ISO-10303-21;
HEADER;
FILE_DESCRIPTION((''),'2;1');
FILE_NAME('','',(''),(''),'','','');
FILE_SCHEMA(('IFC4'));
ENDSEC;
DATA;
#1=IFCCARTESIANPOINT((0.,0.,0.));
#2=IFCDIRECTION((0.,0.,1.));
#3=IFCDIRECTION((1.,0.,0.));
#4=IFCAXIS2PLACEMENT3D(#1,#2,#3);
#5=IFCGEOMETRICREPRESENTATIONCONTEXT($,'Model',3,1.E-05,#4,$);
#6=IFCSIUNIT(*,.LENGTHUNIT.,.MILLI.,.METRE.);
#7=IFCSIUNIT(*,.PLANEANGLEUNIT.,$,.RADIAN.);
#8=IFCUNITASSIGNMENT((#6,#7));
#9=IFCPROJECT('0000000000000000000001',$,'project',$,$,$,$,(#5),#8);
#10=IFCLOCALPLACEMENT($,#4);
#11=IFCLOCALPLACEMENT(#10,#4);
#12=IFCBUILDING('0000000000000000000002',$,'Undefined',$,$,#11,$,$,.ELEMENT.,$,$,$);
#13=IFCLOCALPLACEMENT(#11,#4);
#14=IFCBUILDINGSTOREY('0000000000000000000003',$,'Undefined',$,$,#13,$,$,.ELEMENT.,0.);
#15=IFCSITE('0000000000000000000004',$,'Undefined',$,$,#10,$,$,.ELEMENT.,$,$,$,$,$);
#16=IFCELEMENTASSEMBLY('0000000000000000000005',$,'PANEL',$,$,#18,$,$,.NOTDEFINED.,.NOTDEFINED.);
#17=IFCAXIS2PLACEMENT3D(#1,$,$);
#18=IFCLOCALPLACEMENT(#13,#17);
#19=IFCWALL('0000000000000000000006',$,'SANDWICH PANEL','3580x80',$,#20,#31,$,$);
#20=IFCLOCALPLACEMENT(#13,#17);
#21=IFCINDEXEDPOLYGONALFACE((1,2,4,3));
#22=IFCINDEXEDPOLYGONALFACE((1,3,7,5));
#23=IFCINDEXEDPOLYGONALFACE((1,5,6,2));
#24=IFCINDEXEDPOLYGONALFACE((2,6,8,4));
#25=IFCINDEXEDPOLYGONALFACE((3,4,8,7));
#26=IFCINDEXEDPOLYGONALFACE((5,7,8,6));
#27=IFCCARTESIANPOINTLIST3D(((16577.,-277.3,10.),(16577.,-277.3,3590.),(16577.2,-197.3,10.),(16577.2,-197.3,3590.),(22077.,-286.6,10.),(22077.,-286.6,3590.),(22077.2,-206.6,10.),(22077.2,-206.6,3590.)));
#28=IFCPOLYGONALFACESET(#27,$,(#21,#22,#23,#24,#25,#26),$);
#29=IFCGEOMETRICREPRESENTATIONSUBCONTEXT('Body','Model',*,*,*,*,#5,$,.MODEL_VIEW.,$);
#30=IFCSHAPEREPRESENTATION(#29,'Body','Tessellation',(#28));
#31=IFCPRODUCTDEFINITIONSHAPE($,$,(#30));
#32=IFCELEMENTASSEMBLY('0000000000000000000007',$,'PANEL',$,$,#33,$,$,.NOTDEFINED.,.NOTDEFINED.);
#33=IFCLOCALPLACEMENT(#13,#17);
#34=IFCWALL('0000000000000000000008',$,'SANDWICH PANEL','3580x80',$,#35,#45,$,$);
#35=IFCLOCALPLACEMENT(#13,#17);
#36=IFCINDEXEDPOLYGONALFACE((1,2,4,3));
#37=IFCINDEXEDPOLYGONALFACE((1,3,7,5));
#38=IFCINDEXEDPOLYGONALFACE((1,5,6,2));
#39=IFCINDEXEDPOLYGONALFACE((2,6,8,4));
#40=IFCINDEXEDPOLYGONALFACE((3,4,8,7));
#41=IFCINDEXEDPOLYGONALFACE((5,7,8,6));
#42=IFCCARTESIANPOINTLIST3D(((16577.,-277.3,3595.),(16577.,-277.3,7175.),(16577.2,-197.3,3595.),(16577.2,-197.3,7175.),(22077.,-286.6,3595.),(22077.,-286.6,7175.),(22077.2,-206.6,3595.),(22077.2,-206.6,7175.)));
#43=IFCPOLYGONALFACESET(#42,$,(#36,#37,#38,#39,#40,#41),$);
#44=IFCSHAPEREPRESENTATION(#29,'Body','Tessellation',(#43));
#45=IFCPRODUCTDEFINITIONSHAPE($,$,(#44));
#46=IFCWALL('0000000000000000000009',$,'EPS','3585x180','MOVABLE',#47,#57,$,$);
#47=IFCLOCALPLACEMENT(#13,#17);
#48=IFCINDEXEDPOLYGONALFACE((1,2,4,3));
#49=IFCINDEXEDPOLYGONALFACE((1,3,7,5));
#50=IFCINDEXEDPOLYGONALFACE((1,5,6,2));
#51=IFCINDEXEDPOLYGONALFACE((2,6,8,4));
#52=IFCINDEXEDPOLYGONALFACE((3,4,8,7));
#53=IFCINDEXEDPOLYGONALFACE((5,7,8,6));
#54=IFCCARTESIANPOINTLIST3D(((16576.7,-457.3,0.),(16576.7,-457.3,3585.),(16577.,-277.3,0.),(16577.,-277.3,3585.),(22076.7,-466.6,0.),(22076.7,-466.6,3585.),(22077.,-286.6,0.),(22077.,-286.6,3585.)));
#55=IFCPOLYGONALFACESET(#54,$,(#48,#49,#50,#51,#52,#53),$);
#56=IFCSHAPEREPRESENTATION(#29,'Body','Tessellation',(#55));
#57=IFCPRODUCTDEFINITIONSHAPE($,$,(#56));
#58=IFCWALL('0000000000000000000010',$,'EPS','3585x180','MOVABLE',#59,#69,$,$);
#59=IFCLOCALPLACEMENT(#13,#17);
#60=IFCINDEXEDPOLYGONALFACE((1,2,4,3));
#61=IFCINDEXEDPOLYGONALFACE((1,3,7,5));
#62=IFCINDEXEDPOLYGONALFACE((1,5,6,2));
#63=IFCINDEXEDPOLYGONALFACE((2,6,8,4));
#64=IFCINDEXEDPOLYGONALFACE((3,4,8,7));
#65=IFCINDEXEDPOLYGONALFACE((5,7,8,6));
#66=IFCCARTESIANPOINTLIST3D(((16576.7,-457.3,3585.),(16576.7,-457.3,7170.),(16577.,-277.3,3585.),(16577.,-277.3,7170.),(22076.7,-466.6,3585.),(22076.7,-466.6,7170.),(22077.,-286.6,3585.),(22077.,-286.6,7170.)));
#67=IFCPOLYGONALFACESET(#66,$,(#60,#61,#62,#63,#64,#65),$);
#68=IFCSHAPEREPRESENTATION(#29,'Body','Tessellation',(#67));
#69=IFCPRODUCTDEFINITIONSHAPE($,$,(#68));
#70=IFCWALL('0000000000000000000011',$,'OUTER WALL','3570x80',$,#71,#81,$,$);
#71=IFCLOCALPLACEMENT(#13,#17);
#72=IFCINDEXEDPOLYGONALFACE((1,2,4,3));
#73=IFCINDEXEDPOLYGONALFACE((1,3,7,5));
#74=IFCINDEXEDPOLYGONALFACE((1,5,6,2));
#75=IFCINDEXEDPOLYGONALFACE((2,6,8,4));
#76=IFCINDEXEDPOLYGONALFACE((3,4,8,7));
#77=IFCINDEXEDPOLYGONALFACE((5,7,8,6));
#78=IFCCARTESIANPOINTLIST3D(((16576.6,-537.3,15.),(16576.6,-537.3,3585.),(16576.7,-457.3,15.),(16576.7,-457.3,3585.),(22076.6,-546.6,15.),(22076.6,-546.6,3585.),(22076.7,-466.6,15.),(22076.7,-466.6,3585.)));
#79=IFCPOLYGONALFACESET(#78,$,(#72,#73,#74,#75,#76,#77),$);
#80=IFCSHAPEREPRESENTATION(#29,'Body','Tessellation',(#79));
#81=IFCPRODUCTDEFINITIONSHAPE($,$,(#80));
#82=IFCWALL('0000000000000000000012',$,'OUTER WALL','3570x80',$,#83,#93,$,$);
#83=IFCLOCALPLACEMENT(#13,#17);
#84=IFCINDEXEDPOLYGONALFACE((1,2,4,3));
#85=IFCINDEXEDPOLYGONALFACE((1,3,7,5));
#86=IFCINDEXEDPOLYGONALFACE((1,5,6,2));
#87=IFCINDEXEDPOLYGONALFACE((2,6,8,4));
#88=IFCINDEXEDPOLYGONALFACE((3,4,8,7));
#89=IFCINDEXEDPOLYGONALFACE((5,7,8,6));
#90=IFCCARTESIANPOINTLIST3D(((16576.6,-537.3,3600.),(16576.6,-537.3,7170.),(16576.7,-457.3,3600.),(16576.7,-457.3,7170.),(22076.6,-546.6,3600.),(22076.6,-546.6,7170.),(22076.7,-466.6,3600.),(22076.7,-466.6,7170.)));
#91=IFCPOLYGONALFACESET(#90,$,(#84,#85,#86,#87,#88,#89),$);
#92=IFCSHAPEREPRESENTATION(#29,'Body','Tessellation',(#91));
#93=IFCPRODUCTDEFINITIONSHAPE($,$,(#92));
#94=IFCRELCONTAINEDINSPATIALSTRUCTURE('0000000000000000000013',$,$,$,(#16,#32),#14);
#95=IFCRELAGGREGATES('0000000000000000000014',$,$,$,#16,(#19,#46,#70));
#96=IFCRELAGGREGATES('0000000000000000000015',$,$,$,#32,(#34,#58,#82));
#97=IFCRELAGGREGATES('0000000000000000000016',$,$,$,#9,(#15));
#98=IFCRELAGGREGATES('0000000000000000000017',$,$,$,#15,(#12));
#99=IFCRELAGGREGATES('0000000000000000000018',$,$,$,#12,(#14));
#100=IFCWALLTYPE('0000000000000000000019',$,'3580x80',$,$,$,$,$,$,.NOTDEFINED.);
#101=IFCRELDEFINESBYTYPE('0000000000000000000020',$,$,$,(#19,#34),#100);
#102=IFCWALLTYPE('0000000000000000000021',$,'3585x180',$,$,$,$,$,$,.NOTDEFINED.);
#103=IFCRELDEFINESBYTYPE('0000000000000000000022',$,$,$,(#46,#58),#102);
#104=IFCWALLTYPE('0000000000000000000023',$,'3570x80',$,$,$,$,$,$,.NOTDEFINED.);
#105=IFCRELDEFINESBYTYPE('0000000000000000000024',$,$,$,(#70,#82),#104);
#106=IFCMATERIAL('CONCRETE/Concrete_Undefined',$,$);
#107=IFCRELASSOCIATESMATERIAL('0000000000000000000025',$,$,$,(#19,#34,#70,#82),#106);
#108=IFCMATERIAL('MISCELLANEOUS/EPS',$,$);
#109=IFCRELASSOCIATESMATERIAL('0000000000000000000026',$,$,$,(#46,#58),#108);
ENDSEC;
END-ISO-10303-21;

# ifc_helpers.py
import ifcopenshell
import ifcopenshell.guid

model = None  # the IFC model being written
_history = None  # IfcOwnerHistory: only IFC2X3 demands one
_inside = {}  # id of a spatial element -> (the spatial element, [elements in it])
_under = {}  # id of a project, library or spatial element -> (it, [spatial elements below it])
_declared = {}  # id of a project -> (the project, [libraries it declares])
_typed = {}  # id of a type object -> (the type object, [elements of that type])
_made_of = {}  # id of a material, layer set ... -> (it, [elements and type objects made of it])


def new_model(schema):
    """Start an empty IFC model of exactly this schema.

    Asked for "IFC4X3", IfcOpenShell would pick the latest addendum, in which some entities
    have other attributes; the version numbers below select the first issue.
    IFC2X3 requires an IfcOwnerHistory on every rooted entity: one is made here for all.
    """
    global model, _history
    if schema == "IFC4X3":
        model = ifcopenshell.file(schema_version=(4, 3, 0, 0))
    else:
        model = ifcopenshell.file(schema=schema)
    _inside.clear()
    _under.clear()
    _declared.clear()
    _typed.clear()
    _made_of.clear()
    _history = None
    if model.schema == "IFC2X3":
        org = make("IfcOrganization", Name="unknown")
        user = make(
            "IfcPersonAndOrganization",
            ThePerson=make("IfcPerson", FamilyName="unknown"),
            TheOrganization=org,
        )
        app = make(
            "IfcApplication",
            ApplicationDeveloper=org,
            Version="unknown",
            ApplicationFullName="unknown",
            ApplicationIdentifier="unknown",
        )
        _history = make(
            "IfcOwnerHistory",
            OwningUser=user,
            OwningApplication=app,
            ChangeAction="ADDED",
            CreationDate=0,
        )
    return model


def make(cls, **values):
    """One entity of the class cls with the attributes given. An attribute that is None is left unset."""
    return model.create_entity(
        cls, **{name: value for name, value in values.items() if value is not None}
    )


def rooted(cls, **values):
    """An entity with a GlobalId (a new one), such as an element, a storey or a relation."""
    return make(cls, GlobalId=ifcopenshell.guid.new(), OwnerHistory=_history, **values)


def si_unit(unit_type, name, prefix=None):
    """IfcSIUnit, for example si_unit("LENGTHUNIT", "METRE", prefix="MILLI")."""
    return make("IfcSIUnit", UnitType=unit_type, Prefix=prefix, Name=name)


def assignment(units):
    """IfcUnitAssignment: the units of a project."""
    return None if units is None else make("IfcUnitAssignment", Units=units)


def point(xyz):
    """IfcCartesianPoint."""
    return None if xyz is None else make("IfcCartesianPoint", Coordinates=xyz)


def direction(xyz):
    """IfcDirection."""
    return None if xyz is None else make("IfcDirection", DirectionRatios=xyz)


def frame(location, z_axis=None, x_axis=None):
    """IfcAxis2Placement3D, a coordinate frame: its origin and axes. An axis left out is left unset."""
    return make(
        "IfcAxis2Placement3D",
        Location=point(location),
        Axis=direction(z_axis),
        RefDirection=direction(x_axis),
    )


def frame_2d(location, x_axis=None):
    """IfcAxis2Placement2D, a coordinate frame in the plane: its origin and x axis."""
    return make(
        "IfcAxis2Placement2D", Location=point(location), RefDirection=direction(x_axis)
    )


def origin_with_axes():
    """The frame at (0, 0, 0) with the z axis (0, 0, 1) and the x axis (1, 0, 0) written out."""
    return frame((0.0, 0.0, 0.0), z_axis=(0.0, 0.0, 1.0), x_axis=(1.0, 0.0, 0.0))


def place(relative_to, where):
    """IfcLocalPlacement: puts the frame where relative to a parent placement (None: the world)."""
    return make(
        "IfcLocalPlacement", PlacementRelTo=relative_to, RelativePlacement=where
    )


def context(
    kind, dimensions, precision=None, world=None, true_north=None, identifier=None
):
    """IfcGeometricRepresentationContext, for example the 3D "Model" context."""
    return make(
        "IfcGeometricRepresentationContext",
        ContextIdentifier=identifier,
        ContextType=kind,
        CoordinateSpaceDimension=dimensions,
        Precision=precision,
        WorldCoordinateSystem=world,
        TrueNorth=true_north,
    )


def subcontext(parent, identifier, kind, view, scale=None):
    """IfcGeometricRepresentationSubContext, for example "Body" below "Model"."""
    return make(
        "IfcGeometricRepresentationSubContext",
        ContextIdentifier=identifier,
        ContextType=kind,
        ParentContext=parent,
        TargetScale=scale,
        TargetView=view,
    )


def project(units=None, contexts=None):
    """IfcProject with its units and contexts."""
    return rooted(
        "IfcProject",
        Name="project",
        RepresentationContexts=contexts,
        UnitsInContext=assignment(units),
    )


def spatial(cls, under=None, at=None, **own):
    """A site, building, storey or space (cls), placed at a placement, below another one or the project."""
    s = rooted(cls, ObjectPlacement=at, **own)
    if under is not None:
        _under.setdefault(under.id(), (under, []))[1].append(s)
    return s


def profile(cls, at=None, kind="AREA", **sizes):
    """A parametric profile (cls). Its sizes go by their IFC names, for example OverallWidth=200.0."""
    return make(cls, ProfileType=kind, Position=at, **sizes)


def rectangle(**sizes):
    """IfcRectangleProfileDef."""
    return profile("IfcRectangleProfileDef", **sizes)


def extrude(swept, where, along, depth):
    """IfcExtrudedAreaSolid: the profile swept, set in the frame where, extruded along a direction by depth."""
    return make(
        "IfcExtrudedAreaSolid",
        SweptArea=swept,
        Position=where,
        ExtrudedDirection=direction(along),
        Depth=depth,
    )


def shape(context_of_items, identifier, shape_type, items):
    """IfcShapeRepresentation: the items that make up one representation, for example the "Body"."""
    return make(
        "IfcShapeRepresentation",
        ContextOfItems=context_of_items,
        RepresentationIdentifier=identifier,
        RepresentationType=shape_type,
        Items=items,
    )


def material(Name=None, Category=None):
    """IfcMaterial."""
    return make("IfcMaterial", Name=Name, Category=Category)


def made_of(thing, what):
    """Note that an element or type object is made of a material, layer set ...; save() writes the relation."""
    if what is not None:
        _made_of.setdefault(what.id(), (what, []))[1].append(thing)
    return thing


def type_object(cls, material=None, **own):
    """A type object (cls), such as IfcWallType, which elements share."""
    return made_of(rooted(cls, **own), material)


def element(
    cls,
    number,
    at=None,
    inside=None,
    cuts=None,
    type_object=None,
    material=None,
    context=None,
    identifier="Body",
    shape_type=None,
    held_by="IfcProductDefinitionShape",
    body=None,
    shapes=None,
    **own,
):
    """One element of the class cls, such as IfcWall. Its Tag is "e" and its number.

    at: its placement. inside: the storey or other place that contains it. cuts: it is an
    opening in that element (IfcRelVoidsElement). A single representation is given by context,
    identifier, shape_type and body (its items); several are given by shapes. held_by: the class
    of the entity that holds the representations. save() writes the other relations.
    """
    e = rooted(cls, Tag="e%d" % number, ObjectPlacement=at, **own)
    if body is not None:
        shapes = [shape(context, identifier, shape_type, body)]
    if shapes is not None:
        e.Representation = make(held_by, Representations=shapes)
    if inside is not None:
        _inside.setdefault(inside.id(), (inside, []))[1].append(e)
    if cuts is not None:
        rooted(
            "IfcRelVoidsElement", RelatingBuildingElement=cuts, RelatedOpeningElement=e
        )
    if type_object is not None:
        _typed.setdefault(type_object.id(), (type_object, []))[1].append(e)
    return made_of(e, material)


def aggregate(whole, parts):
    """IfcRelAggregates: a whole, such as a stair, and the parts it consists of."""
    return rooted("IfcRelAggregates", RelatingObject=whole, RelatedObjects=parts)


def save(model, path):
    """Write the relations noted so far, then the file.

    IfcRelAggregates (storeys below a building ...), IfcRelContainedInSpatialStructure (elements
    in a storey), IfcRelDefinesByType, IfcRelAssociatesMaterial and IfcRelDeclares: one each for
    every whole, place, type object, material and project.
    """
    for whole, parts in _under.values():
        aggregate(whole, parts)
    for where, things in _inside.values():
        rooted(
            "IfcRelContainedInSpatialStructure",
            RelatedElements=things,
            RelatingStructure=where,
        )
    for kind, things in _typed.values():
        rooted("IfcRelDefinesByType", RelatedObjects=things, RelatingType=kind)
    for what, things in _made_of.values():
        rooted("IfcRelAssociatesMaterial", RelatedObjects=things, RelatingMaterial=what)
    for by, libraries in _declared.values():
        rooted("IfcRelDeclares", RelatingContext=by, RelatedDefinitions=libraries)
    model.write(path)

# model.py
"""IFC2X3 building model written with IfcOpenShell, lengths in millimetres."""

from ifc_helpers import new_model, si_unit, frame, frame_2d, origin_with_axes, place, context, subcontext, project, spatial, rectangle, extrude, material, type_object, element, aggregate, save


model = new_model("IFC2X3")

# Units and contexts
model_context = context("Model", 3, precision=1e-05, world=origin_with_axes())
body_context = subcontext(model_context, "Body", "Model", "MODEL_VIEW")
ifc_project = project(units=[si_unit("LENGTHUNIT", "METRE", prefix="MILLI"), si_unit("PLANEANGLEUNIT", "RADIAN")], contexts=[model_context])

# Site, building, storey
site_placement = place(None, origin_with_axes())
site = spatial("IfcSite", under=ifc_project, at=site_placement, Name="Undefined", CompositionType="ELEMENT")
building_placement = place(site_placement, origin_with_axes())
building = spatial("IfcBuilding", under=site, at=building_placement, Name="Undefined", CompositionType="ELEMENT")
storey_placement = place(building_placement, origin_with_axes())
storey = spatial("IfcBuildingStorey", under=building, at=storey_placement, Name="Undefined", CompositionType="ELEMENT", Elevation=0.0)

# Shared definitions
ifc_material_1 = material(Name="CONCRETE/Concrete_Undefined")

# Element assemblies, walls
assembly_1_placement = place(storey_placement, origin_with_axes())
assembly_1 = element("IfcElementAssembly", 1, at=assembly_1_placement, inside=storey, Name="PANEL", AssemblyPlace="NOTDEFINED", PredefinedType="NOTDEFINED")
wall_type_1 = type_object("IfcWallType", Name="3580x80", PredefinedType="NOTDEFINED")
wall_1_placement = place(assembly_1_placement, frame((16577.1, -237.3, 10.0), z_axis=(0.0, 0.0, 1.0), x_axis=(0.999999, -0.001684, 0.0)))
wall_1 = element("IfcWall", 2, at=wall_1_placement, type_object=wall_type_1, material=ifc_material_1, Name="SANDWICH PANEL", Description="3580x80", context=body_context, shape_type="SweptSolid", body=[
    extrude(rectangle(XDim=5500.0, YDim=80.0, at=frame_2d((0.0, 2750.0), x_axis=(0.0, -1.0))), frame((0.0, 0.0, 0.0), z_axis=(0.0, 0.0, 1.0), x_axis=(0.0, -1.0, 0.0)), (0.0, 0.0, 1.0), 3580.0),
])
assembly_2_placement = place(storey_placement, origin_with_axes())
assembly_2 = element("IfcElementAssembly", 3, at=assembly_2_placement, inside=storey, Name="PANEL", AssemblyPlace="NOTDEFINED", PredefinedType="NOTDEFINED")
wall_2_placement = place(assembly_2_placement, frame((16577.1, -237.3, 3595.0), z_axis=(0.0, 0.0, 1.0), x_axis=(0.999999, -0.001684, 0.0)))
wall_2 = element("IfcWall", 4, at=wall_2_placement, type_object=wall_type_1, material=ifc_material_1, Name="SANDWICH PANEL", Description="3580x80", context=body_context, shape_type="SweptSolid", body=[
    extrude(rectangle(XDim=5500.0, YDim=80.0, at=frame_2d((0.0, 2750.0), x_axis=(0.0, -1.0))), frame((0.0, 0.0, 0.0), z_axis=(0.0, 0.0, 1.0), x_axis=(0.0, -1.0, 0.0)), (0.0, 0.0, 1.0), 3580.0),
])

# Walls
ifc_material_2 = material(Name="MISCELLANEOUS/EPS")
wall_type_2 = type_object("IfcWallType", Name="3585x180", PredefinedType="NOTDEFINED")
wall_3_placement = place(assembly_1_placement, frame((16576.9, -367.3, 0.0), z_axis=(0.0, 0.0, 1.0), x_axis=(0.999999, -0.001684, 0.0)))
wall_3 = element("IfcWall", 5, at=wall_3_placement, type_object=wall_type_2, material=ifc_material_2, Name="EPS", Description="3585x180", ObjectType="MOVABLE", context=body_context, shape_type="SweptSolid", body=[
    extrude(rectangle(XDim=5500.0, YDim=180.0, at=frame_2d((0.0, 2750.0), x_axis=(0.0, -1.0))), frame((0.0, 0.0, 0.0), z_axis=(0.0, 0.0, 1.0), x_axis=(0.0, -1.0, 0.0)), (0.0, 0.0, 1.0), 3585.0),
])
wall_4_placement = place(assembly_2_placement, frame((16576.9, -367.3, 3585.0), z_axis=(0.0, 0.0, 1.0), x_axis=(0.999999, -0.001684, 0.0)))
wall_4 = element("IfcWall", 6, at=wall_4_placement, type_object=wall_type_2, material=ifc_material_2, Name="EPS", Description="3585x180", ObjectType="MOVABLE", context=body_context, shape_type="SweptSolid", body=[
    extrude(rectangle(XDim=5500.0, YDim=180.0, at=frame_2d((0.0, 2750.0), x_axis=(0.0, -1.0))), frame((0.0, 0.0, 0.0), z_axis=(0.0, 0.0, 1.0), x_axis=(0.0, -1.0, 0.0)), (0.0, 0.0, 1.0), 3585.0),
])
wall_type_3 = type_object("IfcWallType", Name="3570x80", PredefinedType="NOTDEFINED")
wall_5_placement = place(assembly_1_placement, frame((16576.7, -497.3, 15.0), z_axis=(0.0, 0.0, 1.0), x_axis=(0.999999, -0.001684, 0.0)))
wall_5 = element("IfcWall", 7, at=wall_5_placement, type_object=wall_type_3, material=ifc_material_1, Name="OUTER WALL", Description="3570x80", context=body_context, shape_type="SweptSolid", body=[
    extrude(rectangle(XDim=5500.0, YDim=80.0, at=frame_2d((0.0, 2750.0), x_axis=(0.0, -1.0))), frame((0.0, 0.0, 0.0), z_axis=(0.0, 0.0, 1.0), x_axis=(0.0, -1.0, 0.0)), (0.0, 0.0, 1.0), 3570.0),
])
aggregate(assembly_1, [wall_1, wall_3, wall_5])
wall_6_placement = place(assembly_2_placement, frame((16576.7, -497.3, 3600.0), z_axis=(0.0, 0.0, 1.0), x_axis=(0.999999, -0.001684, 0.0)))
wall_6 = element("IfcWall", 8, at=wall_6_placement, type_object=wall_type_3, material=ifc_material_1, Name="OUTER WALL", Description="3570x80", context=body_context, shape_type="SweptSolid", body=[
    extrude(rectangle(XDim=5500.0, YDim=80.0, at=frame_2d((0.0, 2750.0), x_axis=(0.0, -1.0))), frame((0.0, 0.0, 0.0), z_axis=(0.0, 0.0, 1.0), x_axis=(0.0, -1.0, 0.0)), (0.0, 0.0, 1.0), 3570.0),
])
aggregate(assembly_2, [wall_2, wall_4, wall_6])

save(model, "model.ifc")
